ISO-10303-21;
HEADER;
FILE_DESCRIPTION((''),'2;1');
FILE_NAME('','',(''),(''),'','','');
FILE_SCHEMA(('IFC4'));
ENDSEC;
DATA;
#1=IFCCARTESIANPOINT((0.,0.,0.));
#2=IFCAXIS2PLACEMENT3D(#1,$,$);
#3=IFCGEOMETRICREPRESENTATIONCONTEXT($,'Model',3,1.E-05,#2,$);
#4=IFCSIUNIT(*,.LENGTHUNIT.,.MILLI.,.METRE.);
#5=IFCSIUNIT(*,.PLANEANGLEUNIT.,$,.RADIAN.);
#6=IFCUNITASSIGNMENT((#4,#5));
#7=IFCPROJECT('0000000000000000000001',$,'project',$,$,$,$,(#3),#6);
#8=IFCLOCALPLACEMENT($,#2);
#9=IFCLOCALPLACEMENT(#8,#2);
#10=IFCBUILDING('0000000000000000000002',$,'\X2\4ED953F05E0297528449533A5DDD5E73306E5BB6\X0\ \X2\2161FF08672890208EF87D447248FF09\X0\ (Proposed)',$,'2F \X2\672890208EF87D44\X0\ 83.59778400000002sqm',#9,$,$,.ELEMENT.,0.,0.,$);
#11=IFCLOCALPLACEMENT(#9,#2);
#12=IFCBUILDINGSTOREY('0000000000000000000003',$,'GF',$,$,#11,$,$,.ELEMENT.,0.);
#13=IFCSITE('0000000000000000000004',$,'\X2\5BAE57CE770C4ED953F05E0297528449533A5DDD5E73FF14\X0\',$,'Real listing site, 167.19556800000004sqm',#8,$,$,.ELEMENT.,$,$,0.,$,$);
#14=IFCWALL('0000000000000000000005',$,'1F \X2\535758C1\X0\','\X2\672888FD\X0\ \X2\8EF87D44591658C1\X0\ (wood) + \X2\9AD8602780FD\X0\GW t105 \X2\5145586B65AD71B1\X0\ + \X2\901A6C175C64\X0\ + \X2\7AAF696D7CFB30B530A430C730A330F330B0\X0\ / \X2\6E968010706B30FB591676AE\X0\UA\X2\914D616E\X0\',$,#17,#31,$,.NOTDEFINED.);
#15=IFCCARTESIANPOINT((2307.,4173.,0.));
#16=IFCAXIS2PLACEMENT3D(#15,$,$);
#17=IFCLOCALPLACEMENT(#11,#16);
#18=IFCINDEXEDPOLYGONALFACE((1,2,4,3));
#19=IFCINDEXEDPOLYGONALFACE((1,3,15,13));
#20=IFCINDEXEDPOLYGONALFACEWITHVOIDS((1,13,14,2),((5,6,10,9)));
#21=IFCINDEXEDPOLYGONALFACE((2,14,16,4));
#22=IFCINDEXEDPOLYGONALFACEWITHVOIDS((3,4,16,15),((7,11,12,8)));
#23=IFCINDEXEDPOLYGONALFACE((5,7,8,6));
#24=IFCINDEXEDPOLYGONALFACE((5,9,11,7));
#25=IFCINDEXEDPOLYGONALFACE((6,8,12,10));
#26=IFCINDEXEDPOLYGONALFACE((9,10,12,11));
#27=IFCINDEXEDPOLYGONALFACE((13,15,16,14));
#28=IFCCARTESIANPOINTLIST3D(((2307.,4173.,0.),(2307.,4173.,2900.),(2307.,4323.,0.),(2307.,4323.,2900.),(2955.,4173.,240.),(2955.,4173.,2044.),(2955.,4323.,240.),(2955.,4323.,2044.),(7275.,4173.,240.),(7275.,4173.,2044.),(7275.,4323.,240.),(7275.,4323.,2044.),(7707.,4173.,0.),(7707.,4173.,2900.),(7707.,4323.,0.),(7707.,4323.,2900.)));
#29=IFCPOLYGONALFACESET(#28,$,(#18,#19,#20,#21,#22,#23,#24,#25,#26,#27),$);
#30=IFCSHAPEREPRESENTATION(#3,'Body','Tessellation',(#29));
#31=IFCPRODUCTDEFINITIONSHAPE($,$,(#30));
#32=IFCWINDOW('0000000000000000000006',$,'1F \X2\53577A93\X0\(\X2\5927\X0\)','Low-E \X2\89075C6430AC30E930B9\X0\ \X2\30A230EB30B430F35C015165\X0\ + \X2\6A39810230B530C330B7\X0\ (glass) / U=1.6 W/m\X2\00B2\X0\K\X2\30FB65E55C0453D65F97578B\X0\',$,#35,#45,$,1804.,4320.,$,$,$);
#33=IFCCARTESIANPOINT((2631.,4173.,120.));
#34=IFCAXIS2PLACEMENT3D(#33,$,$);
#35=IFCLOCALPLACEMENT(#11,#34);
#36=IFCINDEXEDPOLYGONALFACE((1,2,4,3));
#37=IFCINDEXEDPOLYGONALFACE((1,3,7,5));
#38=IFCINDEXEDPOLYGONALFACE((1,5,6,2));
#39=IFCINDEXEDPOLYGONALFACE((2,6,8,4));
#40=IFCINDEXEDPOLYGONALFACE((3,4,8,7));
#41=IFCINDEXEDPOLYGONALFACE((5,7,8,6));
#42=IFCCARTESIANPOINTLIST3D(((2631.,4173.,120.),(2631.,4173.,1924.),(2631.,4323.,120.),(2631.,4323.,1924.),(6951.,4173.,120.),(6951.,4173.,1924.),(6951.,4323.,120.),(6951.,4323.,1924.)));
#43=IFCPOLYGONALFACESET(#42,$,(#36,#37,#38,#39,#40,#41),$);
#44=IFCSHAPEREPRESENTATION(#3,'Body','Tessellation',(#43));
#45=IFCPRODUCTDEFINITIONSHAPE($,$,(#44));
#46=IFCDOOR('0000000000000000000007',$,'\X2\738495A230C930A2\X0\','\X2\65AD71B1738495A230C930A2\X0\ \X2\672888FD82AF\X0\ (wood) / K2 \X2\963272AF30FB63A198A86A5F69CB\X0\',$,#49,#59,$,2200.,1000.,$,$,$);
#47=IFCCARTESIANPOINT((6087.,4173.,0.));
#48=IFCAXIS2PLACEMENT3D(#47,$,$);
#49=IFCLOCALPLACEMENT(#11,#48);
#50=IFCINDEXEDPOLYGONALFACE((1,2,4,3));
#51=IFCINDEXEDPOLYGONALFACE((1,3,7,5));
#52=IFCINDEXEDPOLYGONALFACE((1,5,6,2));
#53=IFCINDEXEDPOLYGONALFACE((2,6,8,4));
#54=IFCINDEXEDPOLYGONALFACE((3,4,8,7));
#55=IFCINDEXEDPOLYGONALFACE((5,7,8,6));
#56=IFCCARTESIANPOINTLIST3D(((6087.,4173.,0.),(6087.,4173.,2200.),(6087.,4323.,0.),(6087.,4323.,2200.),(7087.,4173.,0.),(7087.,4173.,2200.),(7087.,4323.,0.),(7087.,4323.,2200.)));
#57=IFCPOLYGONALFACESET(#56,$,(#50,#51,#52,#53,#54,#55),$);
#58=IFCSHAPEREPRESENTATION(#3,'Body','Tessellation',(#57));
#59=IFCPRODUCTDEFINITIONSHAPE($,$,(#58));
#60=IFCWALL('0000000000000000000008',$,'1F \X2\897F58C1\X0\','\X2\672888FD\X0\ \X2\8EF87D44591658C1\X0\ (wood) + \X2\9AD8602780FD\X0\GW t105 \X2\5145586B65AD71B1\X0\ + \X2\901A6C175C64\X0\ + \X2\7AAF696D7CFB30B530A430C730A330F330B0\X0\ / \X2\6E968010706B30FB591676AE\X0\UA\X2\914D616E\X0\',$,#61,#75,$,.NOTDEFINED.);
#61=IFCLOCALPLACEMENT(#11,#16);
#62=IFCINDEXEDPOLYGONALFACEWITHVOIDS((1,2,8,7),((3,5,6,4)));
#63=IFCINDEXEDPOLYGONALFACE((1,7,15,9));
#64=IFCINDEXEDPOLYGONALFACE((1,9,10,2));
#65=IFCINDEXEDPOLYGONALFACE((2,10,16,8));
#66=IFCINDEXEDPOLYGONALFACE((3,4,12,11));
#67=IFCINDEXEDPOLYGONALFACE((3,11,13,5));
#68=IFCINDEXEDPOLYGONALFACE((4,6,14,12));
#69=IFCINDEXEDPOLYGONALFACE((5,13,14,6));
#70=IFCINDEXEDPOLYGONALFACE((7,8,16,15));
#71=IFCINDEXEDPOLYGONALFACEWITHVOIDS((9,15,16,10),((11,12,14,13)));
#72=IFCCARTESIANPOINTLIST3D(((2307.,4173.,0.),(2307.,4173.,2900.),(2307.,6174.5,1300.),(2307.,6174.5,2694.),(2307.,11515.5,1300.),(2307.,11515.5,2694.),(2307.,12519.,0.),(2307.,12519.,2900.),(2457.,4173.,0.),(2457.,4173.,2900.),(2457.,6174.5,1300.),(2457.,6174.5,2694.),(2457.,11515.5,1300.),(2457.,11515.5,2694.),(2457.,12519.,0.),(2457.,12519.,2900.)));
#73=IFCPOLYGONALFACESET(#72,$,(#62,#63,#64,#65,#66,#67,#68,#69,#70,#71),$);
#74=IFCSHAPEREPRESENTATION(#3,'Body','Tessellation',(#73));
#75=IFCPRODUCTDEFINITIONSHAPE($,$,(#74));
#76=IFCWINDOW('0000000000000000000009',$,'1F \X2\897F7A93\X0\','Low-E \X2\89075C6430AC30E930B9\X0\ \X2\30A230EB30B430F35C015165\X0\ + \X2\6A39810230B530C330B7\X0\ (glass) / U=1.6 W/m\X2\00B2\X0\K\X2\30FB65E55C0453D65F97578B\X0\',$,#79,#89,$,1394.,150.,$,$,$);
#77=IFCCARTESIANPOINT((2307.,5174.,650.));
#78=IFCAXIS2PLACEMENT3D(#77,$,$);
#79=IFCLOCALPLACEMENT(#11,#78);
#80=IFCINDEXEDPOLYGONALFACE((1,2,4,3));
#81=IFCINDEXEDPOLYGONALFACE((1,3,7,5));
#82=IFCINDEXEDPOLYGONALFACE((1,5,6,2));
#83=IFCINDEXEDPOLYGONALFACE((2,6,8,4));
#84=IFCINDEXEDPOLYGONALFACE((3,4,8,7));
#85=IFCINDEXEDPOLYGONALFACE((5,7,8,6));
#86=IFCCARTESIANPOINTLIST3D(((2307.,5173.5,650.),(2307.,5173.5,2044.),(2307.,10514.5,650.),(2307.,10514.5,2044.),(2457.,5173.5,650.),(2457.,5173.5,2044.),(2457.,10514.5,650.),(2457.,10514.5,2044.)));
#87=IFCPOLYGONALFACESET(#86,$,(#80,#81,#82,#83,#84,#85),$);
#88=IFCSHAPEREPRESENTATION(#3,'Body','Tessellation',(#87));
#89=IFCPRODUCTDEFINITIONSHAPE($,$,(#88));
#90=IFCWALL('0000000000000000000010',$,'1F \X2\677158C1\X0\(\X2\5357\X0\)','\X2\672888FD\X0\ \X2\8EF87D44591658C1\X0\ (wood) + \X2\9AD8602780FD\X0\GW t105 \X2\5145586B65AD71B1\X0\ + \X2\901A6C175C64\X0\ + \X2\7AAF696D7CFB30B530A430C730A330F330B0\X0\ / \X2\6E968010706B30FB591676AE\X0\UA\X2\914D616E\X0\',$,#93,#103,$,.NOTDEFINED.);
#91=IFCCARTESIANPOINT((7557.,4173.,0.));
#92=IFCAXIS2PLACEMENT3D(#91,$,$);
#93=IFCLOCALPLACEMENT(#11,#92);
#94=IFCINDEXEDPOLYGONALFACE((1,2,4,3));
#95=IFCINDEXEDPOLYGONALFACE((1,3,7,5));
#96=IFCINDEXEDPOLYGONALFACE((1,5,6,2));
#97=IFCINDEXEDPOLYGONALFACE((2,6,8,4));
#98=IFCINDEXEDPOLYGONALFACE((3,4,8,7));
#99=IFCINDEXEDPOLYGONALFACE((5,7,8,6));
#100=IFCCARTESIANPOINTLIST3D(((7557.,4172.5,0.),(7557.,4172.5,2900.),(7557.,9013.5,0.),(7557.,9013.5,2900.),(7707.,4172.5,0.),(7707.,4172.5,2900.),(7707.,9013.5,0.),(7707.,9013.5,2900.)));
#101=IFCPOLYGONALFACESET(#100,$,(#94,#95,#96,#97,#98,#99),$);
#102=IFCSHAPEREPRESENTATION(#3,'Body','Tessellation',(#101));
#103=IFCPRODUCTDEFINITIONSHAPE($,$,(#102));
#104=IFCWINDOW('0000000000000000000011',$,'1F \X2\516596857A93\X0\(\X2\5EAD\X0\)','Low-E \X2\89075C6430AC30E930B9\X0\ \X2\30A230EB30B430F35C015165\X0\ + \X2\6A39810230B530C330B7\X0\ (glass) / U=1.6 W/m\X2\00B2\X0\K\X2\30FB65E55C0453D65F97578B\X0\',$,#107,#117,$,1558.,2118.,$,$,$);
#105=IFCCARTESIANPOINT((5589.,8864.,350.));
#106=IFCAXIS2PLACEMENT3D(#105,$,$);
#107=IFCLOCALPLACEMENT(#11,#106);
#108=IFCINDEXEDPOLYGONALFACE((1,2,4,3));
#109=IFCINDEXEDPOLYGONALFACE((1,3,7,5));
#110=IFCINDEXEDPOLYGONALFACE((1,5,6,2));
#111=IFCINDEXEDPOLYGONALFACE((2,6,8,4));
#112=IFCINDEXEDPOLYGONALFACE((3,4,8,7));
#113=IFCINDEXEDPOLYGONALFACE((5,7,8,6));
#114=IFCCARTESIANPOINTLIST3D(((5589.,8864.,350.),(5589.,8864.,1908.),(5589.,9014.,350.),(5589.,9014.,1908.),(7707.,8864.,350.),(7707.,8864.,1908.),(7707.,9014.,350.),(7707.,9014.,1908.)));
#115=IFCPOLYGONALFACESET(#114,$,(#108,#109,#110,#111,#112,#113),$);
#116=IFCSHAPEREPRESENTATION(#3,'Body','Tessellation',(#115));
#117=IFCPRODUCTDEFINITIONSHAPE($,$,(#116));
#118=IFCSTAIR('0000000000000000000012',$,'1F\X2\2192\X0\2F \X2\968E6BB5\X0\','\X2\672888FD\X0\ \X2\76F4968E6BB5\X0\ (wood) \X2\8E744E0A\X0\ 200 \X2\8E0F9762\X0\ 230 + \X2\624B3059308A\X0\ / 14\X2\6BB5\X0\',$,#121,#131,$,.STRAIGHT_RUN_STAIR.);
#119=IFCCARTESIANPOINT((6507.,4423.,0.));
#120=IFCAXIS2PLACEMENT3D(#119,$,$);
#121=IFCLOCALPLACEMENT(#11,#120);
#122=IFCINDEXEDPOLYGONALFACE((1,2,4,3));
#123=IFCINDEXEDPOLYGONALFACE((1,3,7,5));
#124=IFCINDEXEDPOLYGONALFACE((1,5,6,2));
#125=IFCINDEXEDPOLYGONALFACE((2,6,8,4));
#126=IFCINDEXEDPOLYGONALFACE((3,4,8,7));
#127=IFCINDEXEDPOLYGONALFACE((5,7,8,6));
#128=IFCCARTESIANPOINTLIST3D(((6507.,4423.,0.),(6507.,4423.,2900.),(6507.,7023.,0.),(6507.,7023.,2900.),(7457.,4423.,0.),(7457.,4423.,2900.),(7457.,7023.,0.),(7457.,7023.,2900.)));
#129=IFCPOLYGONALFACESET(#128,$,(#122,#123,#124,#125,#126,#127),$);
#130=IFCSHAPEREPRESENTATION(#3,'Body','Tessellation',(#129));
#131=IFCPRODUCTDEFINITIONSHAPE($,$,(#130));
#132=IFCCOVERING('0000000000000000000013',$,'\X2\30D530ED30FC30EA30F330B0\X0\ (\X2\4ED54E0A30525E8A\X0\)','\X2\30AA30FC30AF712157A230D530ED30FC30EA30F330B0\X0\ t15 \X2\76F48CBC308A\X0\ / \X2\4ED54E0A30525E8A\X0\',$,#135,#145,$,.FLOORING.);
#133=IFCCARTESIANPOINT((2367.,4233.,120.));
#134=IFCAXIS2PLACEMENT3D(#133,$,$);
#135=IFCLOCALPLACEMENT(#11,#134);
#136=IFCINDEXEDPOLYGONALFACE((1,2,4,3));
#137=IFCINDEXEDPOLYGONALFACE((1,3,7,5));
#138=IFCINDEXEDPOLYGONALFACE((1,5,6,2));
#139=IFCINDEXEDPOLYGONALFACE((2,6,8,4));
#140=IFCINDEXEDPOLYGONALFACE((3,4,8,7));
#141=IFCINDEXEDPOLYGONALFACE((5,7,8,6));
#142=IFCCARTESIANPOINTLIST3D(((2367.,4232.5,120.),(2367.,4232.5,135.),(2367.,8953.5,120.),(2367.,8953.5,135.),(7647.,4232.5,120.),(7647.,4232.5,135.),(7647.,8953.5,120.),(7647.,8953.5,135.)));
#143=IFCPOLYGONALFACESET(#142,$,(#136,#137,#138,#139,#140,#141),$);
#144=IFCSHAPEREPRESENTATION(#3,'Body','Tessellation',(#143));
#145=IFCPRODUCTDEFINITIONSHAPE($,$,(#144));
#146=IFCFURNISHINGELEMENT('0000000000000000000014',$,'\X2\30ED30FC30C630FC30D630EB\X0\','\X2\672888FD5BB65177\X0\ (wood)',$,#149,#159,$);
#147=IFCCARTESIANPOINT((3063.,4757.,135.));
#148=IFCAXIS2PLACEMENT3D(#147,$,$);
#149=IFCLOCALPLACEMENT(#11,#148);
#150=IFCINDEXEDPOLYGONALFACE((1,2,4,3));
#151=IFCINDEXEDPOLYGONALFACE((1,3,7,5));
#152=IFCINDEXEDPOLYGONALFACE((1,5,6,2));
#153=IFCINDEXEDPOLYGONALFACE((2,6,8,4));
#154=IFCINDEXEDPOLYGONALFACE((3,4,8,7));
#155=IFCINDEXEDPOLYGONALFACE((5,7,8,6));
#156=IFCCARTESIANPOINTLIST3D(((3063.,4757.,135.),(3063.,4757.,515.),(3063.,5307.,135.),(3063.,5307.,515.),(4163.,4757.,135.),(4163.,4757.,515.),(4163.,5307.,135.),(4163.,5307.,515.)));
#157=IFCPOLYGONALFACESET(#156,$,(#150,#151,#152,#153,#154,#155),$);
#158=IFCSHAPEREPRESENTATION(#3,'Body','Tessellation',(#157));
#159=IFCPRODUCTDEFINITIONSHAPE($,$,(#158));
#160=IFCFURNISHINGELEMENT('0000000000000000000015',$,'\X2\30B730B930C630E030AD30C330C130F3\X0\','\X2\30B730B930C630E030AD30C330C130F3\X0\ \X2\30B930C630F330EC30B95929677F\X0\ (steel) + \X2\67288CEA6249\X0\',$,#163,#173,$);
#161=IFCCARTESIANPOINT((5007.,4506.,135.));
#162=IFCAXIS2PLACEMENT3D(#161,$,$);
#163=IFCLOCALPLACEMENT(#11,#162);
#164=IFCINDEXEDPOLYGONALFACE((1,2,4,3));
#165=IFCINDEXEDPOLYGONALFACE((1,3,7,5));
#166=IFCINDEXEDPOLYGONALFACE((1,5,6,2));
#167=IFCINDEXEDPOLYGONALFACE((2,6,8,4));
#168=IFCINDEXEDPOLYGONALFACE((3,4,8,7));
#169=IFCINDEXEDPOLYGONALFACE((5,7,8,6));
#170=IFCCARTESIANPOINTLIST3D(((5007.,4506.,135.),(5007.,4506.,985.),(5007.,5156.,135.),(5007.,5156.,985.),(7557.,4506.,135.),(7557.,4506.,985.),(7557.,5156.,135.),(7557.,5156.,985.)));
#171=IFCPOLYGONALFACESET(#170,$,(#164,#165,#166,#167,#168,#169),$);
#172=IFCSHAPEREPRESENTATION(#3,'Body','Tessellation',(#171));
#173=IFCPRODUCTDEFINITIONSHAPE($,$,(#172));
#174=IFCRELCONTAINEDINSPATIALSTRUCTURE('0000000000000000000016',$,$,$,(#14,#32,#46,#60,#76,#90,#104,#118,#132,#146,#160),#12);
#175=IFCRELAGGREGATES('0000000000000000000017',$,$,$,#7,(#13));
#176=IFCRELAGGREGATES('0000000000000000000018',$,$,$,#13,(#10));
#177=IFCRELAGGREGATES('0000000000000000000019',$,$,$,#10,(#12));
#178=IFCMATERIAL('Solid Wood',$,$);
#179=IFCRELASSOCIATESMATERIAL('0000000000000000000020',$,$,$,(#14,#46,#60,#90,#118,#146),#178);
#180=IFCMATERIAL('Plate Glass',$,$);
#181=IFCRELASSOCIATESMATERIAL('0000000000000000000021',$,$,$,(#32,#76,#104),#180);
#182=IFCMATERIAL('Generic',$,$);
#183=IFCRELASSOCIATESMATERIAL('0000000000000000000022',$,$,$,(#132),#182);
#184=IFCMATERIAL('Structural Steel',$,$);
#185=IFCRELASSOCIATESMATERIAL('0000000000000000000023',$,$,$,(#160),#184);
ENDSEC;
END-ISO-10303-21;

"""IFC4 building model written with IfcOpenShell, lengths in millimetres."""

from ifc_helpers import new_model, si_unit, frame, frame_2d, origin, place, context, project, spatial, rectangle, extrude, material, element, fill, save


model = new_model("IFC4")

# Units and contexts
model_context = context("Model", 3, precision=1e-05, world=origin())
ifc_project = project(units=[si_unit("LENGTHUNIT", "METRE", prefix="MILLI"), si_unit("PLANEANGLEUNIT", "RADIAN")], contexts=[model_context])

# Site, building, storey
site_placement = place(None, origin())
site = spatial("IfcSite", under=ifc_project, at=site_placement, Name="宮城県仙台市青葉区川平４", ObjectType="Real listing site, 167.19556800000004sqm", CompositionType="ELEMENT", RefElevation=0.0)
building_placement = place(site_placement, origin())
building = spatial("IfcBuilding", under=site, at=building_placement, Name="仙台市青葉区川平の家 Ⅱ（木造軸組版） (Proposed)", ObjectType="2F 木造軸組 83.59778400000002sqm", CompositionType="ELEMENT", ElevationOfRefHeight=0.0, ElevationOfTerrain=0.0)
storey_placement = place(building_placement, origin())
storey = spatial("IfcBuildingStorey", under=building, at=storey_placement, Name="GF", CompositionType="ELEMENT", Elevation=0.0)

# Shared definitions
ifc_material_1 = material(Name="Solid Wood")

# Wall, openings, window, door
wall_1_placement = place(storey_placement, frame((2307.0, 4173.0, 0.0)))
wall_1 = element("IfcWall", 1, at=wall_1_placement, inside=storey, material=ifc_material_1, Name="1F 南壁", Description="木製 軸組外壁 (wood) + 高性能GW t105 充填断熱 + 通気層 + 窯業系サイディング / 準耐火・外皮UA配慮", PredefinedType="NOTDEFINED", context=model_context, shape_type="SweptSolid", body=[
    extrude(rectangle(XDim=5400.0, YDim=150.0, at=frame_2d((2700.0, 75.0))), frame((2307.0, 4173.0, 0.0)), (0.0, 0.0, 1.0), 2900.0),
])
opening_1_placement = place(storey_placement, frame((2631.0, 4173.0, 120.0)))
opening_1 = element("IfcOpeningElement", 2, at=opening_1_placement, cuts=wall_1, PredefinedType="NOTDEFINED", context=model_context, shape_type="SweptSolid", body=[
    extrude(rectangle(XDim=4320.0, YDim=150.0, at=frame_2d((2160.0, 75.0))), frame((2631.0, 4173.0, 120.0)), (0.0, 0.0, 1.0), 1804.0),
])
opening_2_placement = place(storey_placement, frame((6087.0, 4173.0, 0.0)))
opening_2 = element("IfcOpeningElement", 3, at=opening_2_placement, cuts=wall_1, PredefinedType="NOTDEFINED", context=model_context, shape_type="SweptSolid", body=[
    extrude(rectangle(XDim=1000.0, YDim=150.0, at=frame_2d((500.0, 75.0))), frame((6087.0, 4173.0, 0.0)), (0.0, 0.0, 1.0), 2200.0),
])
ifc_material_2 = material(Name="Plate Glass")
window_1_placement = place(storey_placement, frame((2631.0, 4173.0, 120.0)))
window_1 = element("IfcWindow", 4, at=window_1_placement, inside=storey, material=ifc_material_2, Name="1F 南窓(大)", Description="Low-E 複層ガラス アルゴン封入 + 樹脂サッシ (glass) / U=1.6 W/m²K・日射取得型", OverallHeight=1804.0, OverallWidth=4320.0, context=model_context, shape_type="SweptSolid", body=[
    extrude(rectangle(XDim=4320.0, YDim=150.0, at=frame_2d((2160.0, 75.0))), frame((2631.0, 4173.0, 120.0)), (0.0, 0.0, 1.0), 1804.0),
])
fill(opening_1, window_1)
door_1_placement = place(storey_placement, frame((6087.0, 4173.0, 0.0)))
door_1 = element("IfcDoor", 5, at=door_1_placement, inside=storey, material=ifc_material_1, Name="玄関ドア", Description="断熱玄関ドア 木製芯 (wood) / K2 防犯・採風機構", OverallHeight=2200.0, OverallWidth=1000.0, context=model_context, shape_type="SweptSolid", body=[
    extrude(rectangle(XDim=1000.0, YDim=150.0, at=frame_2d((500.0, 75.0))), frame((6087.0, 4173.0, 0.0)), (0.0, 0.0, 1.0), 2200.0),
])
fill(opening_2, door_1)

# Walls, openings, windows
wall_2_placement = place(storey_placement, frame((2307.0, 4173.0, 0.0)))
wall_2 = element("IfcWall", 6, at=wall_2_placement, inside=storey, material=ifc_material_1, Name="1F 西壁", Description="木製 軸組外壁 (wood) + 高性能GW t105 充填断熱 + 通気層 + 窯業系サイディング / 準耐火・外皮UA配慮", PredefinedType="NOTDEFINED", context=model_context, shape_type="SweptSolid", body=[
    extrude(rectangle(XDim=150.0, YDim=8346.0, at=frame_2d((75.0, 4173.0))), frame((2307.0, 4173.0, 0.0)), (0.0, 0.0, 1.0), 2900.0),
])
opening_3_placement = place(storey_placement, frame((2307.0, 5174.0, 650.0)))
opening_3 = element("IfcOpeningElement", 7, at=opening_3_placement, cuts=wall_2, PredefinedType="NOTDEFINED", context=model_context, shape_type="SweptSolid", body=[
    extrude(rectangle(XDim=150.0, YDim=5341.0, at=frame_2d((75.0, 2670.0))), frame((2307.0, 5174.0, 650.0)), (0.0, 0.0, 1.0), 1394.0),
])
window_2_placement = place(storey_placement, frame((2307.0, 5174.0, 650.0)))
window_2 = element("IfcWindow", 8, at=window_2_placement, inside=storey, material=ifc_material_2, Name="1F 西窓", Description="Low-E 複層ガラス アルゴン封入 + 樹脂サッシ (glass) / U=1.6 W/m²K・日射取得型", OverallHeight=1394.0, OverallWidth=150.0, context=model_context, shape_type="SweptSolid", body=[
    extrude(rectangle(XDim=150.0, YDim=5341.0, at=frame_2d((75.0, 2670.0))), frame((2307.0, 5174.0, 650.0)), (0.0, 0.0, 1.0), 1394.0),
])
fill(opening_3, window_2)
wall_3_placement = place(storey_placement, frame((7557.0, 4173.0, 0.0)))
wall_3 = element("IfcWall", 9, at=wall_3_placement, inside=storey, material=ifc_material_1, Name="1F 東壁(南)", Description="木製 軸組外壁 (wood) + 高性能GW t105 充填断熱 + 通気層 + 窯業系サイディング / 準耐火・外皮UA配慮", PredefinedType="NOTDEFINED", context=model_context, shape_type="SweptSolid", body=[
    extrude(rectangle(XDim=150.0, YDim=4841.0, at=frame_2d((75.0, 2420.0))), frame((7557.0, 4173.0, 0.0)), (0.0, 0.0, 1.0), 2900.0),
])
opening_4_placement = place(storey_placement, frame((5589.0, 8864.0, 350.0)))
opening_4 = element("IfcOpeningElement", 10, at=opening_4_placement, cuts=wall_3, PredefinedType="NOTDEFINED", context=model_context, shape_type="SweptSolid", body=[
    extrude(rectangle(XDim=2118.0, YDim=150.0, at=frame_2d((1059.0, 75.0))), frame((5589.0, 8864.0, 350.0)), (0.0, 0.0, 1.0), 1558.0),
])
window_3_placement = place(storey_placement, frame((5589.0, 8864.0, 350.0)))
window_3 = element("IfcWindow", 11, at=window_3_placement, inside=storey, material=ifc_material_2, Name="1F 入隅窓(庭)", Description="Low-E 複層ガラス アルゴン封入 + 樹脂サッシ (glass) / U=1.6 W/m²K・日射取得型", OverallHeight=1558.0, OverallWidth=2118.0, context=model_context, shape_type="SweptSolid", body=[
    extrude(rectangle(XDim=2118.0, YDim=150.0, at=frame_2d((1059.0, 75.0))), frame((5589.0, 8864.0, 350.0)), (0.0, 0.0, 1.0), 1558.0),
])
fill(opening_4, window_3)

# Stair
stair_placement = place(storey_placement, frame((6507.0, 4423.0, 0.0)))
element("IfcStair", 12, at=stair_placement, inside=storey, material=ifc_material_1, Name="1F→2F 階段", Description="木製 直階段 (wood) 蹴上 200 踏面 230 + 手すり / 14段", PredefinedType="STRAIGHT_RUN_STAIR", context=model_context, shape_type="SweptSolid", body=[
    extrude(rectangle(XDim=950.0, YDim=2600.0, at=frame_2d((475.0, 1300.0))), frame((6507.0, 4423.0, 0.0)), (0.0, 0.0, 1.0), 2900.0),
])

# Covering
ifc_material_3 = material(Name="Generic")
covering_placement = place(storey_placement, frame((2367.0, 4233.0, 120.0)))
element("IfcCovering", 13, at=covering_placement, inside=storey, material=ifc_material_3, Name="フローリング (仕上げ床)", Description="オーク無垢フローリング t15 直貼り / 仕上げ床", PredefinedType="FLOORING", context=model_context, shape_type="SweptSolid", body=[
    extrude(rectangle(XDim=5280.0, YDim=4721.0, at=frame_2d((2640.0, 2360.0))), frame((2367.0, 4233.0, 120.0)), (0.0, 0.0, 1.0), 15.0),
])

# Furnishing elements
furnishing_1_placement = place(storey_placement, frame((3063.0, 4757.0, 135.0)))
element("IfcFurnishingElement", 14, at=furnishing_1_placement, inside=storey, material=ifc_material_1, Name="ローテーブル", Description="木製家具 (wood)", context=model_context, shape_type="SweptSolid", body=[
    extrude(rectangle(XDim=1100.0, YDim=550.0, at=frame_2d((550.0, 275.0))), frame((3063.0, 4757.0, 135.0)), (0.0, 0.0, 1.0), 380.0),
])
ifc_material_4 = material(Name="Structural Steel")
furnishing_2_placement = place(storey_placement, frame((5007.0, 4506.0, 135.0)))
element("IfcFurnishingElement", 15, at=furnishing_2_placement, inside=storey, material=ifc_material_4, Name="システムキッチン", Description="システムキッチン ステンレス天板 (steel) + 木質扉", context=model_context, shape_type="SweptSolid", body=[
    extrude(rectangle(XDim=2550.0, YDim=650.0, at=frame_2d((1275.0, 325.0))), frame((5007.0, 4506.0, 135.0)), (0.0, 0.0, 1.0), 850.0),
])

save(model, "model.ifc")
